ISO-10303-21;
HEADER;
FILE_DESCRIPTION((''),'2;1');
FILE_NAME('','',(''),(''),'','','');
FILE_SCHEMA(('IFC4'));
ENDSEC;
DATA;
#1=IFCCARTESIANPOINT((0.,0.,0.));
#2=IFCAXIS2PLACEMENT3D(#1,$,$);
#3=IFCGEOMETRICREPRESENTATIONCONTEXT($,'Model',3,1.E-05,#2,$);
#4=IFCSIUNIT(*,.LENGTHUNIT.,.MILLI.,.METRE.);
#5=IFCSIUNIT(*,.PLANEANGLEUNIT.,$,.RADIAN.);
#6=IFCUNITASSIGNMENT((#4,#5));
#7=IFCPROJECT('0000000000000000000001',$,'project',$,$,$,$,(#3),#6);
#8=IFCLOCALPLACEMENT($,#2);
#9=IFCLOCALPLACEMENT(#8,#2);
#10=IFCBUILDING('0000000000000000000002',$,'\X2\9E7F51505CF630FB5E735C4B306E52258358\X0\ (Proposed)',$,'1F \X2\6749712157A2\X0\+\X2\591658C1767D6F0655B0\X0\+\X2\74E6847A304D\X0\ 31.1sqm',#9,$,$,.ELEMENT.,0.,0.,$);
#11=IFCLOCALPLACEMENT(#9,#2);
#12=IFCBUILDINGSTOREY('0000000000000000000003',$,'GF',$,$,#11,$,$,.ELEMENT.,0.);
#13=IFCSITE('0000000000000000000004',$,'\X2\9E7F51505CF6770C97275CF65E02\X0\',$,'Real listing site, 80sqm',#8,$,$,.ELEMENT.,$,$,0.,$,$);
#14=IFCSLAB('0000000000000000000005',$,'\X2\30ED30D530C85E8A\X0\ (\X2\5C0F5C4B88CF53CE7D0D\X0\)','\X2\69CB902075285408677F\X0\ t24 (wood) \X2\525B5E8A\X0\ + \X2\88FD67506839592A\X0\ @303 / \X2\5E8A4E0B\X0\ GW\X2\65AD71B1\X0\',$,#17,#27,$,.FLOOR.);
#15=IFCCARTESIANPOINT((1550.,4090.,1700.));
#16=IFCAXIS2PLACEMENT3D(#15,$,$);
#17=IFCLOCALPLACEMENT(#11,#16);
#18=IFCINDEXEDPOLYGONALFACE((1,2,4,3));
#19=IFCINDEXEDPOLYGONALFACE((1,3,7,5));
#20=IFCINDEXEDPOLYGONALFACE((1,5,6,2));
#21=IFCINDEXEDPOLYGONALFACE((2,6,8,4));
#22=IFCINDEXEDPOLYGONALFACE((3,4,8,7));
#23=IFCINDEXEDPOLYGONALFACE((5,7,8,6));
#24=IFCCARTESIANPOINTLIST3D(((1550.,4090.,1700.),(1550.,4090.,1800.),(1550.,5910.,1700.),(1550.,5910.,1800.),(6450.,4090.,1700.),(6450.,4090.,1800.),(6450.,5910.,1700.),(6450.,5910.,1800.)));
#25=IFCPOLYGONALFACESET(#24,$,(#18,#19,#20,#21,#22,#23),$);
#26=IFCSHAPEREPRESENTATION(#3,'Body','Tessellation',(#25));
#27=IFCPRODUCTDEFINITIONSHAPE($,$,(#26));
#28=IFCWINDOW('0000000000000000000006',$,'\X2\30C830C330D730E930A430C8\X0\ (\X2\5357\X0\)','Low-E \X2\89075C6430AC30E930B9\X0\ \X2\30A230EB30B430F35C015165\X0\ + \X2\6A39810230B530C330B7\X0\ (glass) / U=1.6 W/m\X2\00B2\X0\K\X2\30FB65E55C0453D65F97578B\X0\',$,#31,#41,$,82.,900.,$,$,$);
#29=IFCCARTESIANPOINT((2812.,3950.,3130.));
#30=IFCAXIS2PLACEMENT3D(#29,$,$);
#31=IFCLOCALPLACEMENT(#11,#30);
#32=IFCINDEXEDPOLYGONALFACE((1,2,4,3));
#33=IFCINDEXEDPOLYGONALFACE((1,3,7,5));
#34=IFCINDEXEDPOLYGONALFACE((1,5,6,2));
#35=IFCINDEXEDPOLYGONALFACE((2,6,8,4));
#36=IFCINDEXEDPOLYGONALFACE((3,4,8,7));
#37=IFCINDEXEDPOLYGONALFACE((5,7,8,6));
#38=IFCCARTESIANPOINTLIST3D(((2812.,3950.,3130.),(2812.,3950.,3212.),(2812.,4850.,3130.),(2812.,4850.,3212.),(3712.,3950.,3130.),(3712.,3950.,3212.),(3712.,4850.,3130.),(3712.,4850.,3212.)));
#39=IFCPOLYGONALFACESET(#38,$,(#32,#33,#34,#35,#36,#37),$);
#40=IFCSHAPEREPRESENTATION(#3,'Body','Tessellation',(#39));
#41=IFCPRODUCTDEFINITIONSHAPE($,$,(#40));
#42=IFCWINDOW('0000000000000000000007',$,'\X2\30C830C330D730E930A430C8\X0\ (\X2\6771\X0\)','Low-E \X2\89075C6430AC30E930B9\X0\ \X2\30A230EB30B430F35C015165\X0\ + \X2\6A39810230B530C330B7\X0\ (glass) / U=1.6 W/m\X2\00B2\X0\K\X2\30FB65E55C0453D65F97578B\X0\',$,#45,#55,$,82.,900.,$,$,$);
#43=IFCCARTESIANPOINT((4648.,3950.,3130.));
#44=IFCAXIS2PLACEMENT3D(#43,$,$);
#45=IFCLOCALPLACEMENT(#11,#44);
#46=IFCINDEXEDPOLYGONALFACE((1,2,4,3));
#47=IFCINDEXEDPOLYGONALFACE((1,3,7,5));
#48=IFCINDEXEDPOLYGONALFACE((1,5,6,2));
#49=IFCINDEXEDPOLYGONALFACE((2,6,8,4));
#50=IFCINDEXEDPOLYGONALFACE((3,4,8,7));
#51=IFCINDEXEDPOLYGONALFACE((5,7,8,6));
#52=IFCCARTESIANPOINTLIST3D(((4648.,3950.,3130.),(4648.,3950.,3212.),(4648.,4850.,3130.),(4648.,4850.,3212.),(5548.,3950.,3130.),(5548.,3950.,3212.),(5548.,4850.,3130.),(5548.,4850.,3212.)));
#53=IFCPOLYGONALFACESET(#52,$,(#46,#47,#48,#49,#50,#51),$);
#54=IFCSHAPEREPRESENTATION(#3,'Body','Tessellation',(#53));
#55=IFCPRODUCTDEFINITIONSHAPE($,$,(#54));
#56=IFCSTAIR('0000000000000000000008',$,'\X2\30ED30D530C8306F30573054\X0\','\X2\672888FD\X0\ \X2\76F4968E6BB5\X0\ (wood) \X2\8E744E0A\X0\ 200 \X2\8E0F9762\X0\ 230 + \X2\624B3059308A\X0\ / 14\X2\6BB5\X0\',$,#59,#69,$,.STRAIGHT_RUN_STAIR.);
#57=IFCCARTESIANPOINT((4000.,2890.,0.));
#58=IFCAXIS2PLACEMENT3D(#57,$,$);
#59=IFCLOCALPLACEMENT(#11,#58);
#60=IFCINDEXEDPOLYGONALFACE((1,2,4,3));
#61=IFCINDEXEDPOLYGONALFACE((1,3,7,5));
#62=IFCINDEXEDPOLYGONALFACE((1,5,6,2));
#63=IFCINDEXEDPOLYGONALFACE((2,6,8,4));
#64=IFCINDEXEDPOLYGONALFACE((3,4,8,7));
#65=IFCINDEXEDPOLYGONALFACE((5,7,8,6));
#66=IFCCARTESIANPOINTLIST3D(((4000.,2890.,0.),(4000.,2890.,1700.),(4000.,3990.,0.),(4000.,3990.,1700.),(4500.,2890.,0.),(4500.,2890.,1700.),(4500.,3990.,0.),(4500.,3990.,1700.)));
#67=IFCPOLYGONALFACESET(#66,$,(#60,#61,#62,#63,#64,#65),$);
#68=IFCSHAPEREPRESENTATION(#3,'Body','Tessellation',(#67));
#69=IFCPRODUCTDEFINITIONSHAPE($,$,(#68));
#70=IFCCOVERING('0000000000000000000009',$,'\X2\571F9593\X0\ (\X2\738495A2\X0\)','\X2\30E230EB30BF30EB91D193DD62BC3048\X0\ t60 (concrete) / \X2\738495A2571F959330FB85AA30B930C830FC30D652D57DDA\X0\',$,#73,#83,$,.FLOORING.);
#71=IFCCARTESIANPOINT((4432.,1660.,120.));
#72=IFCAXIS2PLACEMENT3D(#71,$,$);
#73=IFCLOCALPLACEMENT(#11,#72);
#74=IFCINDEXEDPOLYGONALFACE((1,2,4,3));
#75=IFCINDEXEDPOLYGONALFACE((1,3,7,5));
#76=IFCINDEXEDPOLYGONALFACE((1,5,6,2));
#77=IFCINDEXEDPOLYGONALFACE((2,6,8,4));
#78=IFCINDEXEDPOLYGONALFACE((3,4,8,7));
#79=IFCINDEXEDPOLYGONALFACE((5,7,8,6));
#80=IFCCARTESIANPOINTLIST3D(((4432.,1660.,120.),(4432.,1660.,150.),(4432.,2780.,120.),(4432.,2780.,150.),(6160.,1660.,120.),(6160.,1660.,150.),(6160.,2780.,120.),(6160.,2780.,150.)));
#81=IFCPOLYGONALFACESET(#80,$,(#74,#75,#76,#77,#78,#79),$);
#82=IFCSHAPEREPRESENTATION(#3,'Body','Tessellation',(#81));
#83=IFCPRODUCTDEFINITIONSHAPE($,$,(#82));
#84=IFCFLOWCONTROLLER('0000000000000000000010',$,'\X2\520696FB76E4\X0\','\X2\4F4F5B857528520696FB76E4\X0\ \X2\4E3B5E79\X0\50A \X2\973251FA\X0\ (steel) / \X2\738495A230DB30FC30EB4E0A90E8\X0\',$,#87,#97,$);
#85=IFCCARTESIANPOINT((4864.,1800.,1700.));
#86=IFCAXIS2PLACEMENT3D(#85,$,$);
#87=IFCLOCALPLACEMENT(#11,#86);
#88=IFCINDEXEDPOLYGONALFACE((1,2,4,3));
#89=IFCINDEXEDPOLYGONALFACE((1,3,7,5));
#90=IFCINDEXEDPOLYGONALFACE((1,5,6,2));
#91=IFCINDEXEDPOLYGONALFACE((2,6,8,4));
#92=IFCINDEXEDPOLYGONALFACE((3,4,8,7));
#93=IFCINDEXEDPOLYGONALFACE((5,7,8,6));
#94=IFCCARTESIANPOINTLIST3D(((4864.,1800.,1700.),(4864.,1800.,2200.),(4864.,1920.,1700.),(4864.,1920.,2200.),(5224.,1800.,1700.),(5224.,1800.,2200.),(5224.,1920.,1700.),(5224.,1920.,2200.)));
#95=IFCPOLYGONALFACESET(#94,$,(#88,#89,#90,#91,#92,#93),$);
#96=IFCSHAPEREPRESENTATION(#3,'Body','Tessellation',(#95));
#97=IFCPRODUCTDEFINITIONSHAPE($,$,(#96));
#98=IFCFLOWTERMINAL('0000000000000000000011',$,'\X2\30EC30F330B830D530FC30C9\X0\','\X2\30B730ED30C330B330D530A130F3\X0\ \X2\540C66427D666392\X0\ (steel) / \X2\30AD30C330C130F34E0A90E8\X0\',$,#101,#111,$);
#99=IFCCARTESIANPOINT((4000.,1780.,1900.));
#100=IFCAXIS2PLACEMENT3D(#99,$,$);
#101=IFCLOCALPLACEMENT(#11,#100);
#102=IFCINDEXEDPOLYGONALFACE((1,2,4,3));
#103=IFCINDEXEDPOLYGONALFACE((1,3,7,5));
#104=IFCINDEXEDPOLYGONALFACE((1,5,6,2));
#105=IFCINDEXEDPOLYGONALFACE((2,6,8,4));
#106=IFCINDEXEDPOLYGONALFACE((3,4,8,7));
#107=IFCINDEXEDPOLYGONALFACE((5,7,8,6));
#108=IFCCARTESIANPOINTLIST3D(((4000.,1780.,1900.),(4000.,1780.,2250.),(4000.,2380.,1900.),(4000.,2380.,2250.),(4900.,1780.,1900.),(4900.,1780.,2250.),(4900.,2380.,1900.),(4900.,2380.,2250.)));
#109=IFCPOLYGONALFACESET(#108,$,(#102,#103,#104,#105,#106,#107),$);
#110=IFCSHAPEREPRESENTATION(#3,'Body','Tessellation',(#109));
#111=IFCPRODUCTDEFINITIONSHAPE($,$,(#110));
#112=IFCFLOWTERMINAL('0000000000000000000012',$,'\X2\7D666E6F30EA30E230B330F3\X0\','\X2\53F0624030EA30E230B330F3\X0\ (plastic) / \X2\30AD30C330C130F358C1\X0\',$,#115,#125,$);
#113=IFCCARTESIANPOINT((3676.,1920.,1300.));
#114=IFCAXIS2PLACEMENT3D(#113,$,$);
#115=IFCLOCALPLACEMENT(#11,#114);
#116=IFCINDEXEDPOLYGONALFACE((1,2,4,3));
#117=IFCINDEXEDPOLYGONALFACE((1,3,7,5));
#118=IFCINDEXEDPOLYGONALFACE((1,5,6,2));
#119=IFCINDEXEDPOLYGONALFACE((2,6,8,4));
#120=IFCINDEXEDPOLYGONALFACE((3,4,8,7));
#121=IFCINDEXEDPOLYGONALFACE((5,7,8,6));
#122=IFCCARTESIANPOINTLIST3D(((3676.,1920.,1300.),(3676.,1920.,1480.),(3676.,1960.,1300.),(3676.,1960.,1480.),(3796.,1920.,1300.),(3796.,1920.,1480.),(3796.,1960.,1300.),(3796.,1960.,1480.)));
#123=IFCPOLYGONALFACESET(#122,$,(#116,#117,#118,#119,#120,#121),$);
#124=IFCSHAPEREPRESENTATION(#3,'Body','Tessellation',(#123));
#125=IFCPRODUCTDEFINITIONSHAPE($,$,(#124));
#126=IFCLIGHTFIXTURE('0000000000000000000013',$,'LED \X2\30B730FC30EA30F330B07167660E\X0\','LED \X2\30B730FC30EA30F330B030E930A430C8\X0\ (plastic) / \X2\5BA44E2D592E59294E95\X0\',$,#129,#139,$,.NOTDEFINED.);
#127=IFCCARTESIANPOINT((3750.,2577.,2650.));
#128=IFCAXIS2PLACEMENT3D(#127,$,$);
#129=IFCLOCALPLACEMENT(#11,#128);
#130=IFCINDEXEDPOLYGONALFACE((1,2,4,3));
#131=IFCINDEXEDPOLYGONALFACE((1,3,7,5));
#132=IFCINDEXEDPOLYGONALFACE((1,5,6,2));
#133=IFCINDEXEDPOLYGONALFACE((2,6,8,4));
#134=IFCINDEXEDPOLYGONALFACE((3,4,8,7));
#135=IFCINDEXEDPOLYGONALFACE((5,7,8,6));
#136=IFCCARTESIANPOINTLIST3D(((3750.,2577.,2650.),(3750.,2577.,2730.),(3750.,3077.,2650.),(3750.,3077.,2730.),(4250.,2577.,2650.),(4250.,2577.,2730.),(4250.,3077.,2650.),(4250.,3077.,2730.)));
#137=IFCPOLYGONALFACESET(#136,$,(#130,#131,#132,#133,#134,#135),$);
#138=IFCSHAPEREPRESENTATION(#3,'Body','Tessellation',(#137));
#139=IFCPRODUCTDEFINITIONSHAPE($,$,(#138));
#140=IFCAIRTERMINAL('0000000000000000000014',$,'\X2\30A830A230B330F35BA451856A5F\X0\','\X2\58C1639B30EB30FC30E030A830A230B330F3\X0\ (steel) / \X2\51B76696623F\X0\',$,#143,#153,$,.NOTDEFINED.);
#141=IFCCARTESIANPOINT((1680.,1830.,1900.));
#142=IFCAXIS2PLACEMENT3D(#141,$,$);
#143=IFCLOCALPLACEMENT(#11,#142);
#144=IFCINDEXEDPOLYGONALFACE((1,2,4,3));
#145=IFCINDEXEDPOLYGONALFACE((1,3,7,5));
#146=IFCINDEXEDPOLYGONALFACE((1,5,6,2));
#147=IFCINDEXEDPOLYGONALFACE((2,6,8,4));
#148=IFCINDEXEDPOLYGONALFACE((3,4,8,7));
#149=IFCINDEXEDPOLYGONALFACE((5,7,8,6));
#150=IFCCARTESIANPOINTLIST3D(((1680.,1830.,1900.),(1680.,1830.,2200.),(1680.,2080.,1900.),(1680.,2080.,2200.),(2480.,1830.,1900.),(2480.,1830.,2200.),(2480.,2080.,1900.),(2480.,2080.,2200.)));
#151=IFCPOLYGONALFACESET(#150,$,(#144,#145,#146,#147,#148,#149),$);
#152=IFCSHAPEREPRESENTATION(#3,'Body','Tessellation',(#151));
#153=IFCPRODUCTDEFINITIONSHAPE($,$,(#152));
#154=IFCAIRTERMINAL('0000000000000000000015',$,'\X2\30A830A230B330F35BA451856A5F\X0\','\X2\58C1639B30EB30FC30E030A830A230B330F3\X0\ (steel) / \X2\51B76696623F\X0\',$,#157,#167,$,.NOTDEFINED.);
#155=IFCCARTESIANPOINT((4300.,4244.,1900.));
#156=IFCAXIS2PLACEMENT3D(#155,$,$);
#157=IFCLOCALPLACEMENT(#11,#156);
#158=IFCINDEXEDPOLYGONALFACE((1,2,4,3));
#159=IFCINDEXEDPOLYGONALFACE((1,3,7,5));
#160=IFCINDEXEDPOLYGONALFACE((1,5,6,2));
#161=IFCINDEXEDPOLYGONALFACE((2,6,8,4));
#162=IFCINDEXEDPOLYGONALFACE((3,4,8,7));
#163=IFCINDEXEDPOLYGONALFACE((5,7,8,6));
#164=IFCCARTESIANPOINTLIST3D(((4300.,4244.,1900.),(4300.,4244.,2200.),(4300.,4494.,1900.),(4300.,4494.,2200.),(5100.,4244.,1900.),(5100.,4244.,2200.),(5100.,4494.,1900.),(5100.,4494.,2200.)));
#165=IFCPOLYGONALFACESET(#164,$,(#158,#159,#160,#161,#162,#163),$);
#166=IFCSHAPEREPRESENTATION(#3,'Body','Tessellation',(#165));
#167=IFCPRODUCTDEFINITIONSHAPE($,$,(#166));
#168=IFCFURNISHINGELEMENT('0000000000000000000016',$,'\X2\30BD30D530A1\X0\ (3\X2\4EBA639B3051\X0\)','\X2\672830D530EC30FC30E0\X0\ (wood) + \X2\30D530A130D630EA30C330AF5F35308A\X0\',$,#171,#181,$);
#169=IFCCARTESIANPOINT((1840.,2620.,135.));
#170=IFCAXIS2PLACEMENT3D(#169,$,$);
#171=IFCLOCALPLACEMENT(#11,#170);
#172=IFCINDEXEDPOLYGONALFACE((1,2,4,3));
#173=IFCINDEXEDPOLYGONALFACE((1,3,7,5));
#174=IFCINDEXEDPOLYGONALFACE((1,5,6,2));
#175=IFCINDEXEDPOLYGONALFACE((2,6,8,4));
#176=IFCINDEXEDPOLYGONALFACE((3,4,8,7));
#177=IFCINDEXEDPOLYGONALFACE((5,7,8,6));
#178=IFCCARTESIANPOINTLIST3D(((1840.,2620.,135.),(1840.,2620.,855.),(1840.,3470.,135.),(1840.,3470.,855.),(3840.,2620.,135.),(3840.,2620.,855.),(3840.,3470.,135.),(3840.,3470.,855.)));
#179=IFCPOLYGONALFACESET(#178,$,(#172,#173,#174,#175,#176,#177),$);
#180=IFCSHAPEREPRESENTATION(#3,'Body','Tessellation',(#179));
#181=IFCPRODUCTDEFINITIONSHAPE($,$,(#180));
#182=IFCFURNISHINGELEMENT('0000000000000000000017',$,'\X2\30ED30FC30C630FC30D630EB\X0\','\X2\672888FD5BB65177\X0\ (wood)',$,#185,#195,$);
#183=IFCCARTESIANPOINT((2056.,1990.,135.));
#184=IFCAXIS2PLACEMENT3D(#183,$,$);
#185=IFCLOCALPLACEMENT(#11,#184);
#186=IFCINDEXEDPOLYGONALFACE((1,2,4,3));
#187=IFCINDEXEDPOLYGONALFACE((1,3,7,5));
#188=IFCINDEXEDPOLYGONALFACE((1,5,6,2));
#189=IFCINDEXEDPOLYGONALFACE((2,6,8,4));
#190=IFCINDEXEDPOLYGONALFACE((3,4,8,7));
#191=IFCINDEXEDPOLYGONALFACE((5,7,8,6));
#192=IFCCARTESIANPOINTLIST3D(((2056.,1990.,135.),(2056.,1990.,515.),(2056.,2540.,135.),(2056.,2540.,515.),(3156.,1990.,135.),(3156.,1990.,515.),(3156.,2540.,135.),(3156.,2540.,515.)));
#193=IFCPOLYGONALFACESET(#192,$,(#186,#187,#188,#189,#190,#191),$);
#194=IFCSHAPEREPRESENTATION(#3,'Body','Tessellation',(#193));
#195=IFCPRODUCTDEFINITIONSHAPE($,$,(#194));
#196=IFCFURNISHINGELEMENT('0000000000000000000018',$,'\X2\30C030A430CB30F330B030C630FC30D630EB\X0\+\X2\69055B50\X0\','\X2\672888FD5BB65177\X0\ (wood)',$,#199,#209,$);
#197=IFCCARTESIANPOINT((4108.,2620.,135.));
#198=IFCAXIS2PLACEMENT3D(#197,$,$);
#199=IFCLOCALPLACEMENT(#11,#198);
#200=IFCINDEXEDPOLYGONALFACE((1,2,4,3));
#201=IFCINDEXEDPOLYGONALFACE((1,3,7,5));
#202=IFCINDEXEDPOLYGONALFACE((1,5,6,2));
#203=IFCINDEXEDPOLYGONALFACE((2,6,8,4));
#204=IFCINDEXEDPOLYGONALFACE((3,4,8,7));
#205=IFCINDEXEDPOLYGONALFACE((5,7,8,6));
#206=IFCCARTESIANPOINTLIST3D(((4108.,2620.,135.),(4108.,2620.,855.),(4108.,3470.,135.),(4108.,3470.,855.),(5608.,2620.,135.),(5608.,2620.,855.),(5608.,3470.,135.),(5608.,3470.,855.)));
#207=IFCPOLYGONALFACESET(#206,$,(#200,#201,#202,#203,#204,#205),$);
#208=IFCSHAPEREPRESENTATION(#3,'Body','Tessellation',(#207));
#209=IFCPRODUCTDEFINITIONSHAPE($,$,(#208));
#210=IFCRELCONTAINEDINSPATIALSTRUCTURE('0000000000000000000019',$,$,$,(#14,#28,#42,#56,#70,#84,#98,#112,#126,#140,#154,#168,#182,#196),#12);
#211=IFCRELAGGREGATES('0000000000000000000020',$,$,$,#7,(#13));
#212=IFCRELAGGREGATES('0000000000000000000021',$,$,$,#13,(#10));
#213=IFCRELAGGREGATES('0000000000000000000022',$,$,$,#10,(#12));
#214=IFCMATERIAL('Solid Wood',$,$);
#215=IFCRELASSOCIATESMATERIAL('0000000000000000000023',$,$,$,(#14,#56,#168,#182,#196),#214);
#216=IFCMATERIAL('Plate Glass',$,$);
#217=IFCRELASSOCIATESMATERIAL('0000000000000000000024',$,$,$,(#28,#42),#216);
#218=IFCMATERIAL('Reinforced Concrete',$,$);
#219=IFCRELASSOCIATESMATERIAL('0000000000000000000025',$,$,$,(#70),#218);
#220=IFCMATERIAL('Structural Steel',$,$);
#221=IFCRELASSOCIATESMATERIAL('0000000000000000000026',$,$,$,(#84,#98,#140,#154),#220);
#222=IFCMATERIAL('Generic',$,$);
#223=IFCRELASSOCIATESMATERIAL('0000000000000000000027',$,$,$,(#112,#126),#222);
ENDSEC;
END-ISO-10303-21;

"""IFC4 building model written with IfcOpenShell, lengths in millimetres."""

from ifc_helpers import new_model, si_unit, frame, frame_2d, origin, place, context, project, spatial, rectangle, extrude, material, element, save


model = new_model("IFC4")

# Units and contexts
model_context = context("Model", 3, precision=1e-05, world=origin())
ifc_project = project(units=[si_unit("LENGTHUNIT", "METRE", prefix="MILLI"), si_unit("PLANEANGLEUNIT", "RADIAN")], contexts=[model_context])

# Site, building, storey
site_placement = place(None, origin())
site = spatial("IfcSite", under=ifc_project, at=site_placement, Name="鹿児島県霧島市", ObjectType="Real listing site, 80sqm", CompositionType="ELEMENT", RefElevation=0.0)
building_placement = place(site_placement, origin())
building = spatial("IfcBuilding", under=site, at=building_placement, Name="鹿児島・平屋の別荘 (Proposed)", ObjectType="1F 杉無垢+外壁白漆喰+瓦葺き 31.1sqm", CompositionType="ELEMENT", ElevationOfRefHeight=0.0, ElevationOfTerrain=0.0)
storey_placement = place(building_placement, origin())
storey = spatial("IfcBuildingStorey", under=building, at=storey_placement, Name="GF", CompositionType="ELEMENT", Elevation=0.0)

# Shared definitions
ifc_material_1 = material(Name="Solid Wood")

# Slab
slab_placement = place(storey_placement, frame((1550.0, 4090.0, 1700.0)))
element("IfcSlab", 1, at=slab_placement, inside=storey, material=ifc_material_1, Name="ロフト床 (小屋裏収納)", Description="構造用合板 t24 (wood) 剛床 + 製材根太 @303 / 床下 GW断熱", PredefinedType="FLOOR", context=model_context, shape_type="SweptSolid", body=[
    extrude(rectangle(XDim=4900.0, YDim=1820.0, at=frame_2d((2450.0, 910.0))), frame((1550.0, 4090.0, 1700.0)), (0.0, 0.0, 1.0), 100.0),
])

# Windows
ifc_material_2 = material(Name="Plate Glass")
window_1_placement = place(storey_placement, frame((2812.0, 3950.0, 3130.0)))
element("IfcWindow", 2, at=window_1_placement, inside=storey, material=ifc_material_2, Name="トップライト (南)", Description="Low-E 複層ガラス アルゴン封入 + 樹脂サッシ (glass) / U=1.6 W/m²K・日射取得型", OverallHeight=82.0, OverallWidth=900.0, context=model_context, shape_type="SweptSolid", body=[
    extrude(rectangle(XDim=900.0, YDim=900.0, at=frame_2d((450.0, 450.0))), frame((2812.0, 3950.0, 3130.0)), (0.0, 0.0, 1.0), 82.0),
])
window_2_placement = place(storey_placement, frame((4648.0, 3950.0, 3130.0)))
element("IfcWindow", 3, at=window_2_placement, inside=storey, material=ifc_material_2, Name="トップライト (東)", Description="Low-E 複層ガラス アルゴン封入 + 樹脂サッシ (glass) / U=1.6 W/m²K・日射取得型", OverallHeight=82.0, OverallWidth=900.0, context=model_context, shape_type="SweptSolid", body=[
    extrude(rectangle(XDim=900.0, YDim=900.0, at=frame_2d((450.0, 450.0))), frame((4648.0, 3950.0, 3130.0)), (0.0, 0.0, 1.0), 82.0),
])

# Stair
stair_placement = place(storey_placement, frame((4000.0, 2890.0, 0.0)))
element("IfcStair", 4, at=stair_placement, inside=storey, material=ifc_material_1, Name="ロフトはしご", Description="木製 直階段 (wood) 蹴上 200 踏面 230 + 手すり / 14段", PredefinedType="STRAIGHT_RUN_STAIR", context=model_context, shape_type="SweptSolid", body=[
    extrude(rectangle(XDim=500.0, YDim=1100.0, at=frame_2d((250.0, 550.0))), frame((4000.0, 2890.0, 0.0)), (0.0, 0.0, 1.0), 1700.0),
])

# Covering
ifc_material_3 = material(Name="Reinforced Concrete")
covering_placement = place(storey_placement, frame((4432.0, 1660.0, 120.0)))
element("IfcCovering", 5, at=covering_placement, inside=storey, material=ifc_material_3, Name="土間 (玄関)", Description="モルタル金鏝押え t60 (concrete) / 玄関土間・薪ストーブ動線", PredefinedType="FLOORING", context=model_context, shape_type="SweptSolid", body=[
    extrude(rectangle(XDim=1728.0, YDim=1120.0, at=frame_2d((864.0, 560.0))), frame((4432.0, 1660.0, 120.0)), (0.0, 0.0, 1.0), 30.0),
])

# Shared definitions
ifc_material_4 = material(Name="Structural Steel")

# Flow controller
flow_controller_placement = place(storey_placement, frame((4864.0, 1800.0, 1700.0)))
element("IfcFlowController", 6, at=flow_controller_placement, inside=storey, material=ifc_material_4, Name="分電盤", Description="住宅用分電盤 主幹50A 露出 (steel) / 玄関ホール上部", context=model_context, shape_type="SweptSolid", body=[
    extrude(rectangle(XDim=360.0, YDim=120.0, at=frame_2d((180.0, 60.0))), frame((4864.0, 1800.0, 1700.0)), (0.0, 0.0, 1.0), 500.0),
])

# Flow terminals
flow_terminal_1_placement = place(storey_placement, frame((4000.0, 1780.0, 1900.0)))
element("IfcFlowTerminal", 7, at=flow_terminal_1_placement, inside=storey, material=ifc_material_4, Name="レンジフード", Description="シロッコファン 同時給排 (steel) / キッチン上部", context=model_context, shape_type="SweptSolid", body=[
    extrude(rectangle(XDim=900.0, YDim=600.0, at=frame_2d((450.0, 300.0))), frame((4000.0, 1780.0, 1900.0)), (0.0, 0.0, 1.0), 350.0),
])
ifc_material_5 = material(Name="Generic")
flow_terminal_2_placement = place(storey_placement, frame((3676.0, 1920.0, 1300.0)))
element("IfcFlowTerminal", 8, at=flow_terminal_2_placement, inside=storey, material=ifc_material_5, Name="給湯リモコン", Description="台所リモコン (plastic) / キッチン壁", context=model_context, shape_type="SweptSolid", body=[
    extrude(rectangle(XDim=120.0, YDim=40.0, at=frame_2d((60.0, 20.0))), frame((3676.0, 1920.0, 1300.0)), (0.0, 0.0, 1.0), 180.0),
])

# Light fixture
light_fixture_placement = place(storey_placement, frame((3750.0, 2577.0, 2650.0)))
element("IfcLightFixture", 9, at=light_fixture_placement, inside=storey, material=ifc_material_5, Name="LED シーリング照明", Description="LED シーリングライト (plastic) / 室中央天井", PredefinedType="NOTDEFINED", context=model_context, shape_type="SweptSolid", body=[
    extrude(rectangle(XDim=500.0, YDim=500.0, at=frame_2d((250.0, 250.0))), frame((3750.0, 2577.0, 2650.0)), (0.0, 0.0, 1.0), 80.0),
])

# Air terminals
air_terminal_1_placement = place(storey_placement, frame((1680.0, 1830.0, 1900.0)))
element("IfcAirTerminal", 10, at=air_terminal_1_placement, inside=storey, material=ifc_material_4, Name="エアコン室内機", Description="壁掛ルームエアコン (steel) / 冷暖房", PredefinedType="NOTDEFINED", context=model_context, shape_type="SweptSolid", body=[
    extrude(rectangle(XDim=800.0, YDim=250.0, at=frame_2d((400.0, 125.0))), frame((1680.0, 1830.0, 1900.0)), (0.0, 0.0, 1.0), 300.0),
])
air_terminal_2_placement = place(storey_placement, frame((4300.0, 4244.0, 1900.0)))
element("IfcAirTerminal", 11, at=air_terminal_2_placement, inside=storey, material=ifc_material_4, Name="エアコン室内機", Description="壁掛ルームエアコン (steel) / 冷暖房", PredefinedType="NOTDEFINED", context=model_context, shape_type="SweptSolid", body=[
    extrude(rectangle(XDim=800.0, YDim=250.0, at=frame_2d((400.0, 125.0))), frame((4300.0, 4244.0, 1900.0)), (0.0, 0.0, 1.0), 300.0),
])

# Furnishing elements
furnishing_1_placement = place(storey_placement, frame((1840.0, 2620.0, 135.0)))
element("IfcFurnishingElement", 12, at=furnishing_1_placement, inside=storey, material=ifc_material_1, Name="ソファ (3人掛け)", Description="木フレーム (wood) + ファブリック張り", context=model_context, shape_type="SweptSolid", body=[
    extrude(rectangle(XDim=2000.0, YDim=850.0, at=frame_2d((1000.0, 425.0))), frame((1840.0, 2620.0, 135.0)), (0.0, 0.0, 1.0), 720.0),
])
furnishing_2_placement = place(storey_placement, frame((2056.0, 1990.0, 135.0)))
element("IfcFurnishingElement", 13, at=furnishing_2_placement, inside=storey, material=ifc_material_1, Name="ローテーブル", Description="木製家具 (wood)", context=model_context, shape_type="SweptSolid", body=[
    extrude(rectangle(XDim=1100.0, YDim=550.0, at=frame_2d((550.0, 275.0))), frame((2056.0, 1990.0, 135.0)), (0.0, 0.0, 1.0), 380.0),
])
furnishing_3_placement = place(storey_placement, frame((4108.0, 2620.0, 135.0)))
element("IfcFurnishingElement", 14, at=furnishing_3_placement, inside=storey, material=ifc_material_1, Name="ダイニングテーブル+椅子", Description="木製家具 (wood)", context=model_context, shape_type="SweptSolid", body=[
    extrude(rectangle(XDim=1500.0, YDim=850.0, at=frame_2d((750.0, 425.0))), frame((4108.0, 2620.0, 135.0)), (0.0, 0.0, 1.0), 720.0),
])

save(model, "model.ifc")
